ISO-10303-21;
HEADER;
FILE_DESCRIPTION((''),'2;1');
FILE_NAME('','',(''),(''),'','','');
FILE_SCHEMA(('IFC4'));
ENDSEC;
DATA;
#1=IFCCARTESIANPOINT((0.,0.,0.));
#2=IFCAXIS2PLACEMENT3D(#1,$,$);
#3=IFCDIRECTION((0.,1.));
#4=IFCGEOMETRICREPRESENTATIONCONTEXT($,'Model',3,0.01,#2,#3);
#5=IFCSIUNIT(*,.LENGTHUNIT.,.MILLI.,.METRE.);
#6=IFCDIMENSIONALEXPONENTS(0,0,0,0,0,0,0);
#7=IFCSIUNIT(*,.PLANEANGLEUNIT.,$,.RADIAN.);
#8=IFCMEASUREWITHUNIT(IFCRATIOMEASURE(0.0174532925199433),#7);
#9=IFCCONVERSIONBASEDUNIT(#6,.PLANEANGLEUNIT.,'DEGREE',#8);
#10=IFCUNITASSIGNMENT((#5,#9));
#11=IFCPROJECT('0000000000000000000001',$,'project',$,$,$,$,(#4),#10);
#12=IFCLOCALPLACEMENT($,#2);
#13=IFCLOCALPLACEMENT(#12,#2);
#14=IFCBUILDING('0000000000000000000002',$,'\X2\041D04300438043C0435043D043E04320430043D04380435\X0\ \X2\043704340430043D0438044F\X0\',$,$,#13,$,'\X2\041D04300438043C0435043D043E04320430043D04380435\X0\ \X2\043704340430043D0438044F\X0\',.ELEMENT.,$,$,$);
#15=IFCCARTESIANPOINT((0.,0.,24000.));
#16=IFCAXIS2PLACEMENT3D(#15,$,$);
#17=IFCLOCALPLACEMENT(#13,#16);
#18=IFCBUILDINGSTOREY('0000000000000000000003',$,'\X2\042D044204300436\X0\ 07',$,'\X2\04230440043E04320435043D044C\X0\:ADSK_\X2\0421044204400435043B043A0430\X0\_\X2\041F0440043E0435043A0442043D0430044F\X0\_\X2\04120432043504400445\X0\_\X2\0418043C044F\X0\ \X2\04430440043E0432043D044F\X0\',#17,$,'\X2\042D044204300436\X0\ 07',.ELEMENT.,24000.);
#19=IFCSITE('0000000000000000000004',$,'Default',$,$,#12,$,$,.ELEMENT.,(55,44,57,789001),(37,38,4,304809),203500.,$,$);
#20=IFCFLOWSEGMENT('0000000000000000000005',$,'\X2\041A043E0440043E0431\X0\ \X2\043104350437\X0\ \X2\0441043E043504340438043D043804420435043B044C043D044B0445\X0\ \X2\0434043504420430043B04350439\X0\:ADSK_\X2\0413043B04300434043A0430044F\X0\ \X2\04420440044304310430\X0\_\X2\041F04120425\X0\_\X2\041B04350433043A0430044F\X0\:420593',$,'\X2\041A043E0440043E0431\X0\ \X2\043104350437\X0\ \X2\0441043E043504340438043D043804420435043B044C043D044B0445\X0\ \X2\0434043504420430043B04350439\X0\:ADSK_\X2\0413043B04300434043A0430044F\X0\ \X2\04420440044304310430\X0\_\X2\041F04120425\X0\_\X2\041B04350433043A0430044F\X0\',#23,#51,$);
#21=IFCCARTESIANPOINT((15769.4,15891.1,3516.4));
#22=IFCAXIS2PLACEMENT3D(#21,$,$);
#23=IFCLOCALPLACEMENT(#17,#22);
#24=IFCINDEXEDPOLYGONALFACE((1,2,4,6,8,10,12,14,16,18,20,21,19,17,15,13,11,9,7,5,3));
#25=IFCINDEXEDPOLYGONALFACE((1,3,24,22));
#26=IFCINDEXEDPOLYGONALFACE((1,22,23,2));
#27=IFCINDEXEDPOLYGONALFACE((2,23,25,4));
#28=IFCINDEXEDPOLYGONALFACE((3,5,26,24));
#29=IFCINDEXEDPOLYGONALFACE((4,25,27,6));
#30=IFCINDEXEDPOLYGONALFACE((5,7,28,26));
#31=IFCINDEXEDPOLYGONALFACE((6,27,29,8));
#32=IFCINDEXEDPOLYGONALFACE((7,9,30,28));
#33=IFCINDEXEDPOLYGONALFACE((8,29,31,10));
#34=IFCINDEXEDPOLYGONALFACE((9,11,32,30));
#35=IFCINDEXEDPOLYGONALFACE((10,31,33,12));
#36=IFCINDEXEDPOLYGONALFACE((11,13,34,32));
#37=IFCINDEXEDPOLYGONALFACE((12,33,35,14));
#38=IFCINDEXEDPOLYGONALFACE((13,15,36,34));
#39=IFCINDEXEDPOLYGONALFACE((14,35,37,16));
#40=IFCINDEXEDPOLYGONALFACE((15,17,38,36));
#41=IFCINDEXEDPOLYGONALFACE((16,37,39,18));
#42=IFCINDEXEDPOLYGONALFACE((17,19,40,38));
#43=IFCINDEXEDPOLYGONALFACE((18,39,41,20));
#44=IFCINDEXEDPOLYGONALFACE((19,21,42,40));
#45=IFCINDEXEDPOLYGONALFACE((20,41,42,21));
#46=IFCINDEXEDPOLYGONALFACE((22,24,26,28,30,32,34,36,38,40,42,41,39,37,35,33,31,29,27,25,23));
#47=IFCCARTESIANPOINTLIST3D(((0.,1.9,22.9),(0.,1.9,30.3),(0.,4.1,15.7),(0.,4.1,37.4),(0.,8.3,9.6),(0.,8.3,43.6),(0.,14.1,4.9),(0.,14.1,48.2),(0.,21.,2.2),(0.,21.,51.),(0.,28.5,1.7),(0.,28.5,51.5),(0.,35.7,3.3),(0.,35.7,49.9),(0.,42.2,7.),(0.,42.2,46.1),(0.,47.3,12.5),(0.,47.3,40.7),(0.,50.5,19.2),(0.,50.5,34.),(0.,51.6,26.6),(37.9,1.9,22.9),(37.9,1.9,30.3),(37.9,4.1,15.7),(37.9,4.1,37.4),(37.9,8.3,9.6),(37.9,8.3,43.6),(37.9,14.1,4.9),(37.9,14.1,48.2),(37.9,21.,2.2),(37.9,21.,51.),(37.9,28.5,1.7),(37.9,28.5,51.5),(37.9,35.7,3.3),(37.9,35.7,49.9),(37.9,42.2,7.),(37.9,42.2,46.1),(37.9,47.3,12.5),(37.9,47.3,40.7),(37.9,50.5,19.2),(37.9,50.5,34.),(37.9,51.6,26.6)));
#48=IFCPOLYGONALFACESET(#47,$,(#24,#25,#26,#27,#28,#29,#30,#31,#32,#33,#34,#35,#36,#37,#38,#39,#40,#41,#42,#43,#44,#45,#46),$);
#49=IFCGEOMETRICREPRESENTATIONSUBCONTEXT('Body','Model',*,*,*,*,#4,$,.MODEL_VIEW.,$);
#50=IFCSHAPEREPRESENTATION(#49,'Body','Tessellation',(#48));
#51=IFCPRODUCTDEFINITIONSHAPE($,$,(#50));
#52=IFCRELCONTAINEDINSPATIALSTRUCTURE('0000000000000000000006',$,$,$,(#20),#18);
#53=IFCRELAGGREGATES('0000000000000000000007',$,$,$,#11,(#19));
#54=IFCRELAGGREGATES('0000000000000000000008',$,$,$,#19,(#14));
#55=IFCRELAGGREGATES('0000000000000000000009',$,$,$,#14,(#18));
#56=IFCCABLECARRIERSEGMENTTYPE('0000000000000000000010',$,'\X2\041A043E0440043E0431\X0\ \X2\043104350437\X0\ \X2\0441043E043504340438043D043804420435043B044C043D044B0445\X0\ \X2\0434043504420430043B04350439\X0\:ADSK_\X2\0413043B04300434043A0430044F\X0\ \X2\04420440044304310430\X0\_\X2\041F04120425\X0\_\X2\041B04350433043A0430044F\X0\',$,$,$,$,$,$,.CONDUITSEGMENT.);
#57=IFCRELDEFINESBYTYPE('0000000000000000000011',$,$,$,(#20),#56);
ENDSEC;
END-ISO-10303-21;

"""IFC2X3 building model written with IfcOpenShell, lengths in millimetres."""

from ifc_helpers import new_model, entity, si_unit, converted_unit, direction, frame, frame_2d, origin, place, context, subcontext, project, spatial, circle, extrude, type_object, element, save


model = new_model("IFC2X3")

# Units and contexts
model_context = context("Model", 3, precision=0.01, world=origin(), true_north=direction((0.0, 1.0)))
body_context = subcontext(model_context, "Body", "Model", "MODEL_VIEW")
ifc_project = project(units=[si_unit("LENGTHUNIT", "METRE", prefix="MILLI"), converted_unit("PLANEANGLEUNIT", "DEGREE", entity("IfcRatioMeasure", 0.0174532925199433), si_unit("PLANEANGLEUNIT", "RADIAN"), dimensions=[0, 0, 0, 0, 0, 0, 0])], contexts=[model_context])

# Site, building, storey
site_placement = place(None, frame((0.0, 0.0, 0.0)))
site = spatial("IfcSite", under=ifc_project, at=site_placement, Name="Default", CompositionType="ELEMENT", RefLatitude=(55, 44, 57, 789001), RefLongitude=(37, 38, 4, 304809), RefElevation=203500.0)
building_placement = place(site_placement, origin())
building = spatial("IfcBuilding", under=site, at=building_placement, Name="Наименование здания", LongName="Наименование здания", CompositionType="ELEMENT")
storey_placement = place(building_placement, frame((0.0, 0.0, 24000.0)))
storey = spatial("IfcBuildingStorey", under=building, at=storey_placement, Name="Этаж 07", ObjectType="Уровень:ADSK_Стрелка_Проектная_Вверх_Имя уровня", LongName="Этаж 07", CompositionType="ELEMENT", Elevation=24000.0)

# Flow segment
cable_carrier_segment_type_1 = type_object("IfcCableCarrierSegmentType", Name="Короб без соединительных деталей:ADSK_Гладкая труба_ПВХ_Легкая", PredefinedType="CONDUITSEGMENT")
flow_segment_1_placement = place(storey_placement, frame((15769.4, 15891.1, 3516.4)))
element("IfcFlowSegment", 1, at=flow_segment_1_placement, inside=storey, type_object=cable_carrier_segment_type_1, Name="Короб без соединительных деталей:ADSK_Гладкая труба_ПВХ_Легкая:420593", ObjectType="Короб без соединительных деталей:ADSK_Гладкая труба_ПВХ_Легкая", context=body_context, shape_type="SweptSolid", body=[
    extrude(circle(Radius=25.0, at=frame_2d((0.0, 0.0), x_axis=(1.0, 0.0))), frame((0.0, 26.6, 26.6), z_axis=(1.0, 0.0, 0.0), x_axis=(0.0, 1.0, 0.0)), (0.0, 0.0, 1.0), 37.9),
])

save(model, "model.ifc")
